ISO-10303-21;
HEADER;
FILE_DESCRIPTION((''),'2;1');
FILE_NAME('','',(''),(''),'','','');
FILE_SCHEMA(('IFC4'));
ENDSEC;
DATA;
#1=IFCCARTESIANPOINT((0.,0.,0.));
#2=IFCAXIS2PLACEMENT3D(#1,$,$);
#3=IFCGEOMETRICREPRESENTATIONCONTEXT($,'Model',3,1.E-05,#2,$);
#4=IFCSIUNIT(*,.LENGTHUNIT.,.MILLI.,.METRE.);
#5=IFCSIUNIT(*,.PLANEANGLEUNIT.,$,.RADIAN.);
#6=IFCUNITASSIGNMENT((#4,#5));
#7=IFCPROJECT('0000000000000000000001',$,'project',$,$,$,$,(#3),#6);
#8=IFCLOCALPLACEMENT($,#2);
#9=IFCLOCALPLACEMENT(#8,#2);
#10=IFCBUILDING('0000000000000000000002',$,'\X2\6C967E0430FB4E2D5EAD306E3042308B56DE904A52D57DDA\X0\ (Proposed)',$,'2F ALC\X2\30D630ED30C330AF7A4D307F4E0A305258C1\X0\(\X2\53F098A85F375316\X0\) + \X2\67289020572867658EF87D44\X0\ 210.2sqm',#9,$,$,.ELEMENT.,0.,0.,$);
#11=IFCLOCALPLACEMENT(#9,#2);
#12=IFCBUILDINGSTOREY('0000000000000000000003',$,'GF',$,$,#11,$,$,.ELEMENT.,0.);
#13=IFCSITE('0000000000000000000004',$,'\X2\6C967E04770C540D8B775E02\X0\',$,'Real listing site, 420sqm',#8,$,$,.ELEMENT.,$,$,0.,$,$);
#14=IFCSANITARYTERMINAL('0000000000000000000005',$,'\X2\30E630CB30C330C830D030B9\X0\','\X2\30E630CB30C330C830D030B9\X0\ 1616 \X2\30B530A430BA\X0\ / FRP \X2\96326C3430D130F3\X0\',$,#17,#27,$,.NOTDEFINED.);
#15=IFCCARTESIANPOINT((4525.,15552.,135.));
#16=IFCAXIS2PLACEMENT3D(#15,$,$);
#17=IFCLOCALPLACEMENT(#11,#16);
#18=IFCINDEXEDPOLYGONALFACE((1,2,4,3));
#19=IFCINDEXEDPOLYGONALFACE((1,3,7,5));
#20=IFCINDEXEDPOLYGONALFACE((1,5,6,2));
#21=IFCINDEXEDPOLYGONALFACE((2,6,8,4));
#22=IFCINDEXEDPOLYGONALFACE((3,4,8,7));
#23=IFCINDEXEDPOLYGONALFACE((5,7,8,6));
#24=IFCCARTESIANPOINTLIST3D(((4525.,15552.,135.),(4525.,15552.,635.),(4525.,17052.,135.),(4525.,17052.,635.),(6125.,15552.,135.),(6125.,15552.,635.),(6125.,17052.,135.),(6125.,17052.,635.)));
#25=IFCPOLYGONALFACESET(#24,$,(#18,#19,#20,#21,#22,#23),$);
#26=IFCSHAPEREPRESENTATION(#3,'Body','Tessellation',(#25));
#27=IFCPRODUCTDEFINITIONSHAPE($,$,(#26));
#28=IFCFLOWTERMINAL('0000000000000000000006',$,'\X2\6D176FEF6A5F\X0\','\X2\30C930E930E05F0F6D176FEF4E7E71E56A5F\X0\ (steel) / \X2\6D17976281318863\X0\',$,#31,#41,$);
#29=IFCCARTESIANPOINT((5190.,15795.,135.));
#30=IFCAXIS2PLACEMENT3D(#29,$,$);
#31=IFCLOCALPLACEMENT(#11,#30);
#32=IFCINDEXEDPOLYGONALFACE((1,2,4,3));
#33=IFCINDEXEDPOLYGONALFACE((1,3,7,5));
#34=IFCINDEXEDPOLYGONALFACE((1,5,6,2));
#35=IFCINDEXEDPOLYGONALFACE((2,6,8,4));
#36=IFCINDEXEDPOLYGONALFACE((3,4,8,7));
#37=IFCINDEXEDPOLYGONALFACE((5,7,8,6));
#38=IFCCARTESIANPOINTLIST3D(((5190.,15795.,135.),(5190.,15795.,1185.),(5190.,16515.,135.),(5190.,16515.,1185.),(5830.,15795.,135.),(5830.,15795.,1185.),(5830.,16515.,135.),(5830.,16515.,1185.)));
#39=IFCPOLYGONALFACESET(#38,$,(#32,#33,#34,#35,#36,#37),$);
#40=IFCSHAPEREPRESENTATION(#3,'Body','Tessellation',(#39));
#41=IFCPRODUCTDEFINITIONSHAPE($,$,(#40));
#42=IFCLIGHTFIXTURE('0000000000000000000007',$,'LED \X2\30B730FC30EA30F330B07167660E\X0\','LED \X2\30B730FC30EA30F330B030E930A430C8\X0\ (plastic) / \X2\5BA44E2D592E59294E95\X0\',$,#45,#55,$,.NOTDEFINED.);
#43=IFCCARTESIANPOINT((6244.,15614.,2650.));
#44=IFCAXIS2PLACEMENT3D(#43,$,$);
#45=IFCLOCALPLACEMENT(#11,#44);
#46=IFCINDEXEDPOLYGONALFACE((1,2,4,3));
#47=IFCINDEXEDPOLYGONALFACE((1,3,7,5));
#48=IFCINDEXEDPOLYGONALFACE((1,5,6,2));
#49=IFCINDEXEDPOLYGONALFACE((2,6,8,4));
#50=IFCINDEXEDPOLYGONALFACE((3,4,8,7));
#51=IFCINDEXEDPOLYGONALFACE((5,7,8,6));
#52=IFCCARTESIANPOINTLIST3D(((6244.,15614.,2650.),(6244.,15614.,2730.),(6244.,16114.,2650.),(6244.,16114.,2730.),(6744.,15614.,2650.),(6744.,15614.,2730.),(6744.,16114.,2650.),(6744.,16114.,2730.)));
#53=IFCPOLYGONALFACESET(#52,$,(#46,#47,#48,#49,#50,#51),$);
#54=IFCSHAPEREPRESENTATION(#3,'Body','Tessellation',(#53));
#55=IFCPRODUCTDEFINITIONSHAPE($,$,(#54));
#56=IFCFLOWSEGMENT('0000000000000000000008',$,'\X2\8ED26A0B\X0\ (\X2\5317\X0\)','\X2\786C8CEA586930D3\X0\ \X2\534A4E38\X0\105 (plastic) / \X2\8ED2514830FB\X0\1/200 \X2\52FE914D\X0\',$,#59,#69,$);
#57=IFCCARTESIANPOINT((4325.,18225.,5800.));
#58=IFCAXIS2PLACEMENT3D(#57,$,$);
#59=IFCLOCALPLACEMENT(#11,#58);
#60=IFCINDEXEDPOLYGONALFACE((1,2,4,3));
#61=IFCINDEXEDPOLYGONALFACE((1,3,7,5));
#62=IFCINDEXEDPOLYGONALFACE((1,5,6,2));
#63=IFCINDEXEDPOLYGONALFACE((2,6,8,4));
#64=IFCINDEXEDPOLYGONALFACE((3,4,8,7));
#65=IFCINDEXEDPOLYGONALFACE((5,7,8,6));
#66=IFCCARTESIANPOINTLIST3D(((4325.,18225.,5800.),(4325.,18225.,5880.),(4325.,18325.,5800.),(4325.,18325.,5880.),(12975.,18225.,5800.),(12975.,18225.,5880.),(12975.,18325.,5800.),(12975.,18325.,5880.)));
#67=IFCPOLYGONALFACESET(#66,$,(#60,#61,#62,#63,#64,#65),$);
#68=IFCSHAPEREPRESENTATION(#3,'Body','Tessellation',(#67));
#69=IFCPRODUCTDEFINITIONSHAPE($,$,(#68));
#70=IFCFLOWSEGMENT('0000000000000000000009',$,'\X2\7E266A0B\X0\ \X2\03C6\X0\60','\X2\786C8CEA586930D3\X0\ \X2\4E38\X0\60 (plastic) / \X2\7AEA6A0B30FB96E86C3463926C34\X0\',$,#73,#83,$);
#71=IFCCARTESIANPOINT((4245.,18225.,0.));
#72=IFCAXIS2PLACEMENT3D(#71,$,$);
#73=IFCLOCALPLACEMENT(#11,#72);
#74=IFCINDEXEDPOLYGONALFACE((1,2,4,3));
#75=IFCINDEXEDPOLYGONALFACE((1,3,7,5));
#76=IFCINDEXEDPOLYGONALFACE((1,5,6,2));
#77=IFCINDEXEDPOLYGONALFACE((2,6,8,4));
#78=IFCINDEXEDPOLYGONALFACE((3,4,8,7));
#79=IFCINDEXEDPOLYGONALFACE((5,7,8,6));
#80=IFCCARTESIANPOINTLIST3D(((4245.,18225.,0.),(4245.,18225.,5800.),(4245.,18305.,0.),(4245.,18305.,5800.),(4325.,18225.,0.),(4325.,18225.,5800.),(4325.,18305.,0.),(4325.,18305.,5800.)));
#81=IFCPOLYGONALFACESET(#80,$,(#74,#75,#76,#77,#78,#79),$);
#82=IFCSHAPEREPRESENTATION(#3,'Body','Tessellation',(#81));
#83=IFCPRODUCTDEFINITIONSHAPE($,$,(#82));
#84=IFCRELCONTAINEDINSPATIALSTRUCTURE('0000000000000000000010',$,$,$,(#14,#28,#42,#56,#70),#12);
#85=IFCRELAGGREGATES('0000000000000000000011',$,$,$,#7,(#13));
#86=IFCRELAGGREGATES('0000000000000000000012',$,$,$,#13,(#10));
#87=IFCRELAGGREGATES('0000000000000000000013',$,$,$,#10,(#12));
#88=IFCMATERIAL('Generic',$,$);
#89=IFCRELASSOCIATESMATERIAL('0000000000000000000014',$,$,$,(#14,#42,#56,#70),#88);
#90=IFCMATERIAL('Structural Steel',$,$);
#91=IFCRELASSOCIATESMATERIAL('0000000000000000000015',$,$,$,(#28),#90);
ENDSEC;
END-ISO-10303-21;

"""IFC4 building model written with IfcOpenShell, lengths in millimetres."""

from ifc_helpers import new_model, si_unit, frame, frame_2d, origin, place, context, project, spatial, rectangle, extrude, material, element, save


model = new_model("IFC4")

# Units and contexts
model_context = context("Model", 3, precision=1e-05, world=origin())
ifc_project = project(units=[si_unit("LENGTHUNIT", "METRE", prefix="MILLI"), si_unit("PLANEANGLEUNIT", "RADIAN")], contexts=[model_context])

# Site, building, storey
site_placement = place(None, origin())
site = spatial("IfcSite", under=ifc_project, at=site_placement, Name="沖縄県名護市", ObjectType="Real listing site, 420sqm", CompositionType="ELEMENT", RefElevation=0.0)
building_placement = place(site_placement, origin())
building = spatial("IfcBuilding", under=site, at=building_placement, Name="沖縄・中庭のある回遊動線 (Proposed)", ObjectType="2F ALCブロック積み上げ壁(台風強化) + 木造在来軸組 210.2sqm", CompositionType="ELEMENT", ElevationOfRefHeight=0.0, ElevationOfTerrain=0.0)
storey_placement = place(building_placement, origin())
storey = spatial("IfcBuildingStorey", under=building, at=storey_placement, Name="GF", CompositionType="ELEMENT", Elevation=0.0)

# Sanitary terminal
ifc_material_1 = material(Name="Generic")
sanitary_terminal_placement = place(storey_placement, frame((4525.0, 15552.0, 135.0)))
element("IfcSanitaryTerminal", 1, at=sanitary_terminal_placement, inside=storey, material=ifc_material_1, Name="ユニットバス", Description="ユニットバス 1616 サイズ / FRP 防水パン", PredefinedType="NOTDEFINED", context=model_context, shape_type="SweptSolid", body=[
    extrude(rectangle(XDim=1600.0, YDim=1500.0, at=frame_2d((800.0, 750.0))), frame((4525.0, 15552.0, 135.0)), (0.0, 0.0, 1.0), 500.0),
])

# Flow terminal
ifc_material_2 = material(Name="Structural Steel")
flow_terminal_placement = place(storey_placement, frame((5190.0, 15795.0, 135.0)))
element("IfcFlowTerminal", 2, at=flow_terminal_placement, inside=storey, material=ifc_material_2, Name="洗濯機", Description="ドラム式洗濯乾燥機 (steel) / 洗面脱衣", context=model_context, shape_type="SweptSolid", body=[
    extrude(rectangle(XDim=640.0, YDim=720.0, at=frame_2d((320.0, 360.0))), frame((5190.0, 15795.0, 135.0)), (0.0, 0.0, 1.0), 1050.0),
])

# Light fixture
light_fixture_placement = place(storey_placement, frame((6244.0, 15614.0, 2650.0)))
element("IfcLightFixture", 3, at=light_fixture_placement, inside=storey, material=ifc_material_1, Name="LED シーリング照明", Description="LED シーリングライト (plastic) / 室中央天井", PredefinedType="NOTDEFINED", context=model_context, shape_type="SweptSolid", body=[
    extrude(rectangle(XDim=500.0, YDim=500.0, at=frame_2d((250.0, 250.0))), frame((6244.0, 15614.0, 2650.0)), (0.0, 0.0, 1.0), 80.0),
])

# Flow segments
flow_segment_1_placement = place(storey_placement, frame((4325.0, 18225.0, 5800.0)))
element("IfcFlowSegment", 4, at=flow_segment_1_placement, inside=storey, material=ifc_material_1, Name="軒樋 (北)", Description="硬質塩ビ 半丸105 (plastic) / 軒先・1/200 勾配", context=model_context, shape_type="SweptSolid", body=[
    extrude(rectangle(XDim=8650.0, YDim=100.0, at=frame_2d((4325.0, 50.0))), frame((4325.0, 18225.0, 5800.0)), (0.0, 0.0, 1.0), 80.0),
])
flow_segment_2_placement = place(storey_placement, frame((4245.0, 18225.0, 0.0)))
element("IfcFlowSegment", 5, at=flow_segment_2_placement, inside=storey, material=ifc_material_1, Name="縦樋 φ60", Description="硬質塩ビ 丸60 (plastic) / 竪樋・雨水排水", context=model_context, shape_type="SweptSolid", body=[
    extrude(rectangle(XDim=80.0, YDim=80.0, at=frame_2d((40.0, 40.0))), frame((4245.0, 18225.0, 0.0)), (0.0, 0.0, 1.0), 5800.0),
])

save(model, "model.ifc")
